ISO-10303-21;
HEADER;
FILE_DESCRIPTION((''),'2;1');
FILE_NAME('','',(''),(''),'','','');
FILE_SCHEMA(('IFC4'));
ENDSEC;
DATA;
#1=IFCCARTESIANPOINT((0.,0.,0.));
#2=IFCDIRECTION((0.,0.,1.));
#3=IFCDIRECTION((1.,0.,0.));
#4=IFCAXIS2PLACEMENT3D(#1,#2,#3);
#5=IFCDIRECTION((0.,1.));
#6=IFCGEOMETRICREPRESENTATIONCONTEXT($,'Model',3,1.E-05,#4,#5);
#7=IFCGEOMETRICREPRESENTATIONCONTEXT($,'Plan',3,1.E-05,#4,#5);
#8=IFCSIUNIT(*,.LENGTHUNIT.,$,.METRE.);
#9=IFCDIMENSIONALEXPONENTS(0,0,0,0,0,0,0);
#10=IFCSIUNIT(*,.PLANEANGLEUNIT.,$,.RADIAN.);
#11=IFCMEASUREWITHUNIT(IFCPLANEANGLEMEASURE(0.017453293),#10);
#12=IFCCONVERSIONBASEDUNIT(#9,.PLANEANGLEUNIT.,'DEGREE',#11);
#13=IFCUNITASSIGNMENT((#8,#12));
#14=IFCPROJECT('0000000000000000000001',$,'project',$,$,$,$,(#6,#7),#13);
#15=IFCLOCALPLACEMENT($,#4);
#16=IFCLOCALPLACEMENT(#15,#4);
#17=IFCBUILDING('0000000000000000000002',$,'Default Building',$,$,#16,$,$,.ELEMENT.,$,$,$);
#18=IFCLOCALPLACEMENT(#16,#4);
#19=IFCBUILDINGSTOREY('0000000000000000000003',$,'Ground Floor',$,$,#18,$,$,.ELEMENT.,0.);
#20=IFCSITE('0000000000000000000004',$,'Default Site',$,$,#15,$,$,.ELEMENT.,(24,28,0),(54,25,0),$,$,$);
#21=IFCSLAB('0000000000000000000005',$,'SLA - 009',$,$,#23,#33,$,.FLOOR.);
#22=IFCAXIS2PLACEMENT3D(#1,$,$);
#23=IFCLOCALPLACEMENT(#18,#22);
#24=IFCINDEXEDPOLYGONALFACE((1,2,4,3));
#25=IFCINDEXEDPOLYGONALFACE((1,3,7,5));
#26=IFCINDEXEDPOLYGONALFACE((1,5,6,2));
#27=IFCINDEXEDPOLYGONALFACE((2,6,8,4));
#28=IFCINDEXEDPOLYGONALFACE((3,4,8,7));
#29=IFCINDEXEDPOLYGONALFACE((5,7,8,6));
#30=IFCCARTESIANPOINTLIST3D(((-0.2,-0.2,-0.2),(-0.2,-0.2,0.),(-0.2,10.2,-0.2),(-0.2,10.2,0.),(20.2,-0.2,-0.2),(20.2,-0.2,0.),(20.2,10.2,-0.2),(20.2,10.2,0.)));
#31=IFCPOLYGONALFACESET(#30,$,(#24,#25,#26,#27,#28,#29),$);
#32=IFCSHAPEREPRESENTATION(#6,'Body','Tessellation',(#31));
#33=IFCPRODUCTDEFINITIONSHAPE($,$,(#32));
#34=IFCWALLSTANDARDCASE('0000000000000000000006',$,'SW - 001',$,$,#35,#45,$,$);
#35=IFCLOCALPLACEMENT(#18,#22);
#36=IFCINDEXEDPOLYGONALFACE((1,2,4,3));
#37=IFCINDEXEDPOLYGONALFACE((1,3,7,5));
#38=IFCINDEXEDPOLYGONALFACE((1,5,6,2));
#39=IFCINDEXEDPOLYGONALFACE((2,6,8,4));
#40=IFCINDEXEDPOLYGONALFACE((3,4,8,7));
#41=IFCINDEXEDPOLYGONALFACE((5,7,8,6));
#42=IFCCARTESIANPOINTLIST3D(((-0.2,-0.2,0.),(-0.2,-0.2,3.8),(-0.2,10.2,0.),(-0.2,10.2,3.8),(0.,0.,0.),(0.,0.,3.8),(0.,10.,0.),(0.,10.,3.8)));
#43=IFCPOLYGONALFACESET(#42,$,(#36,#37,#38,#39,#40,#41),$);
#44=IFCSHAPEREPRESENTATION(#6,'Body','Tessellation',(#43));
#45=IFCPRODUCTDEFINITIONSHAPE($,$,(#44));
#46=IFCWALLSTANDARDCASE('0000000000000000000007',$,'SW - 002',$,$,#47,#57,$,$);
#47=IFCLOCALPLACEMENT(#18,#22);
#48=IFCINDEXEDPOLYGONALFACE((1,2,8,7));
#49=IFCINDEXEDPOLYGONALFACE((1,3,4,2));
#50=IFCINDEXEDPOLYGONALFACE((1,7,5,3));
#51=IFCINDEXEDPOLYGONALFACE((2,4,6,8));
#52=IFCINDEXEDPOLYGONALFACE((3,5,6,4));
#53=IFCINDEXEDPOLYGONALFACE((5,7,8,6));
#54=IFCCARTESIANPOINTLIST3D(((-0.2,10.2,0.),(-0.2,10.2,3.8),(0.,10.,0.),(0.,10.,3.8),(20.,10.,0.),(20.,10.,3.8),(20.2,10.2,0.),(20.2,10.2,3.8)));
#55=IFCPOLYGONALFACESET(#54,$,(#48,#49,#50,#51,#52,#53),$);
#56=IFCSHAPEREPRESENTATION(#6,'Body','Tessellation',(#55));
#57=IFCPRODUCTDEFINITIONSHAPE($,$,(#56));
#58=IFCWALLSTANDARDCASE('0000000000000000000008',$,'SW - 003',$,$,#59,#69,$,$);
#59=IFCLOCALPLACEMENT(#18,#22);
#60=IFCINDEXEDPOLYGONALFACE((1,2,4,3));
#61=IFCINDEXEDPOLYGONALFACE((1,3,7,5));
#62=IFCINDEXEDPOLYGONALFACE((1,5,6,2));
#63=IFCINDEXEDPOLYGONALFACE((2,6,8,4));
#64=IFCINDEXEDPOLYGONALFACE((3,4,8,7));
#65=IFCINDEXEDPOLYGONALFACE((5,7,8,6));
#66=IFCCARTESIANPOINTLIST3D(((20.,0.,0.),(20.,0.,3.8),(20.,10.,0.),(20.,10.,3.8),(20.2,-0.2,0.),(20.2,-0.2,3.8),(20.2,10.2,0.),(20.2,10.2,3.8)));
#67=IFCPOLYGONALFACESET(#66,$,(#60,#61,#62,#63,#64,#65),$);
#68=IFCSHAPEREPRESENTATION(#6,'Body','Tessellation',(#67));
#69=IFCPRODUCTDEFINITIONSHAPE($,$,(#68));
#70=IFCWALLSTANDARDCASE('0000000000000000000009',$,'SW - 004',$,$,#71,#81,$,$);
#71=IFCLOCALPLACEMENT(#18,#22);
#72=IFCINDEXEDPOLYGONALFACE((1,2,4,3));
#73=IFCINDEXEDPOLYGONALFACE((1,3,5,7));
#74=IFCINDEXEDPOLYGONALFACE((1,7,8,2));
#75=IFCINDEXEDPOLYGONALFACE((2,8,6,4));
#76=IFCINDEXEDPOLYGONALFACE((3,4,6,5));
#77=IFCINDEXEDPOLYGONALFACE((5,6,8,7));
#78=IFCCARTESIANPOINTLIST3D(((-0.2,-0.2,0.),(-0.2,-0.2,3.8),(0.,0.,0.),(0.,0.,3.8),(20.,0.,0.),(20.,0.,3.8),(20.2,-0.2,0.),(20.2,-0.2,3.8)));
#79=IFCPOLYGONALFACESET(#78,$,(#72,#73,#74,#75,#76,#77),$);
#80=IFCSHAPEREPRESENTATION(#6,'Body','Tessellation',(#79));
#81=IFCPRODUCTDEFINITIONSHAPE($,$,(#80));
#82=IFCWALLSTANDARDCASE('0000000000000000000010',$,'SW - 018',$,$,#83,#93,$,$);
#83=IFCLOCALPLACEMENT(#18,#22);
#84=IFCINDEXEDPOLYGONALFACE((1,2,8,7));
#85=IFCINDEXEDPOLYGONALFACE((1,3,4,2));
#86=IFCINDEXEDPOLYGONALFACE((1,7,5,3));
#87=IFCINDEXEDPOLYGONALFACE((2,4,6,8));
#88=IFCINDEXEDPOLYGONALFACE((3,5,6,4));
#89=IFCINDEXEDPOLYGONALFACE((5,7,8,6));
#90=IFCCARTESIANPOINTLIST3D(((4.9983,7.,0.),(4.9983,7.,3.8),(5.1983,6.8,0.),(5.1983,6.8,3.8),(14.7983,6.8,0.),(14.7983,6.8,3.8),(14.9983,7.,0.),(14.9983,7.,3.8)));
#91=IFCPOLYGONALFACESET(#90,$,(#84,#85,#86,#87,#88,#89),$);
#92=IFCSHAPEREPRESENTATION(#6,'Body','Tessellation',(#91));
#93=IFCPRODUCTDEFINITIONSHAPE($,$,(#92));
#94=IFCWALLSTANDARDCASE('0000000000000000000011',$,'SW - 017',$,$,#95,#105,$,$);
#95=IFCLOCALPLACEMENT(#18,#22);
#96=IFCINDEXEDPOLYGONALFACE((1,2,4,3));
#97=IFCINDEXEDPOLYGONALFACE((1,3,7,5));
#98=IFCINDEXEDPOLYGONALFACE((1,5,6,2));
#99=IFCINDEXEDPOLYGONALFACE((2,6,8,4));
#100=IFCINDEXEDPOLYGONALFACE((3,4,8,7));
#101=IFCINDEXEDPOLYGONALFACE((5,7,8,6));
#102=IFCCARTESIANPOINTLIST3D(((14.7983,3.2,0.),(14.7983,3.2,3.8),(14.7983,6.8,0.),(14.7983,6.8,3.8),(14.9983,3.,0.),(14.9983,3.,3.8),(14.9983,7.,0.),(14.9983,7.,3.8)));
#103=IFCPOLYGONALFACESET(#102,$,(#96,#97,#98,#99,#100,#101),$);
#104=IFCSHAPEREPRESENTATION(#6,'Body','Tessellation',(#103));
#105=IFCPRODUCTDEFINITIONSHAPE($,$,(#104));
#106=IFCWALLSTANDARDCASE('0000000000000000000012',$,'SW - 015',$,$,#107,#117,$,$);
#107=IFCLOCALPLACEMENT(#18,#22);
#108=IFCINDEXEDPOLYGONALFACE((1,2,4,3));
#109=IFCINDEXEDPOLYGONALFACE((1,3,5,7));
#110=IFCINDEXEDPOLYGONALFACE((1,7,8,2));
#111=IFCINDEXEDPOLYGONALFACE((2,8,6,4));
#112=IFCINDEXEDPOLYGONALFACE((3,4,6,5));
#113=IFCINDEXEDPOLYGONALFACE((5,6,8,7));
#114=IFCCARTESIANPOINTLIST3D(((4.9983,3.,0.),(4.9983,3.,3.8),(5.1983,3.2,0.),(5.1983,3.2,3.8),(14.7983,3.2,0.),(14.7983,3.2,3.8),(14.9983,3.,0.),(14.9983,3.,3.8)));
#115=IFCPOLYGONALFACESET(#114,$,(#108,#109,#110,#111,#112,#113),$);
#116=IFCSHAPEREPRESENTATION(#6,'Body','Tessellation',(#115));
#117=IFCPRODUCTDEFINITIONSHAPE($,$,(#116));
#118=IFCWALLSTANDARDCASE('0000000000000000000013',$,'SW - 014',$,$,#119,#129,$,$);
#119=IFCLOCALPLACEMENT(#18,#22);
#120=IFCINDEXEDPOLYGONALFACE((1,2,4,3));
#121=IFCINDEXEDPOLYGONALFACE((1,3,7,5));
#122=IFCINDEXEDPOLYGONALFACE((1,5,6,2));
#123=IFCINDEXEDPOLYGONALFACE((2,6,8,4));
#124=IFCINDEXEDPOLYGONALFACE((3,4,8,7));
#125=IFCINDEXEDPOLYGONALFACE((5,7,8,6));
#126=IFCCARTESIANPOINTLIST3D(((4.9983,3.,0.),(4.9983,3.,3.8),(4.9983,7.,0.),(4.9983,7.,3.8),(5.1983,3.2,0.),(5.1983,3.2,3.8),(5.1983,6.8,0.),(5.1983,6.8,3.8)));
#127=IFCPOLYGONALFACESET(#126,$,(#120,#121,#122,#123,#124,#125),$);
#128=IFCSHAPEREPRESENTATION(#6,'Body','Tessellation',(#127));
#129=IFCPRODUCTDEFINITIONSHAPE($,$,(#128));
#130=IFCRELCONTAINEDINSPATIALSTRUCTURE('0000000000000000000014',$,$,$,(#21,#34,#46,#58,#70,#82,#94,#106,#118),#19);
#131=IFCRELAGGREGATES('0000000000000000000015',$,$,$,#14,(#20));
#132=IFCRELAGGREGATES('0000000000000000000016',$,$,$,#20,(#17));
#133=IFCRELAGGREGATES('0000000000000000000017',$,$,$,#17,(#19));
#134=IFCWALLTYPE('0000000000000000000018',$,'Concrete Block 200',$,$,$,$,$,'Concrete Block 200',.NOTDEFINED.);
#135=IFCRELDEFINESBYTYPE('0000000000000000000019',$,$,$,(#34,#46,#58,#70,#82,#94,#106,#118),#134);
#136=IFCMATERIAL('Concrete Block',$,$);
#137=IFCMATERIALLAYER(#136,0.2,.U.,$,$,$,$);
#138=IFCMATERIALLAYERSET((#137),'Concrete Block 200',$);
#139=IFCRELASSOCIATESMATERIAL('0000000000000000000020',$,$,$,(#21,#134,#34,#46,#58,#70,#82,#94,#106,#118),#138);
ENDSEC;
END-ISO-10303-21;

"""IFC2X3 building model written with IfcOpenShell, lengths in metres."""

from ifc_helpers import new_model, entity, si_unit, converted_unit, direction, frame, origin_with_axes, place, context, project, spatial, polyline, outline, extrude, material, layer, layer_set, layer_usage, type_object, element, save


model = new_model("IFC2X3")

# Units and contexts
model_context = context("Model", 3, precision=1e-05, world=origin_with_axes(), true_north=direction((0.0, 1.0)))
plan_context = context("Plan", 3, precision=1e-05, world=origin_with_axes(), true_north=direction((0.0, 1.0)))
ifc_project = project(units=[si_unit("LENGTHUNIT", "METRE"), converted_unit("PLANEANGLEUNIT", "DEGREE", entity("IfcPlaneAngleMeasure", 0.017453293), si_unit("PLANEANGLEUNIT", "RADIAN"), dimensions=[0, 0, 0, 0, 0, 0, 0])], contexts=[model_context, plan_context])

# Site, building, storey
site_placement = place(None, origin_with_axes())
site = spatial("IfcSite", under=ifc_project, at=site_placement, Name="Default Site", CompositionType="ELEMENT", RefLatitude=(24, 28, 0), RefLongitude=(54, 25, 0))
building_placement = place(site_placement, origin_with_axes())
building = spatial("IfcBuilding", under=site, at=building_placement, Name="Default Building", CompositionType="ELEMENT")
storey_placement = place(building_placement, origin_with_axes())
storey = spatial("IfcBuildingStorey", under=building, at=storey_placement, Name="Ground Floor", CompositionType="ELEMENT", Elevation=0.0)

# Slab
ifc_material = material(Name="Concrete Block")
ifc_layer = layer(ifc_material, 0.2, ventilated="UNKNOWN")
ifc_layer_set = layer_set([ifc_layer], Name="Concrete Block 200")
ifc_layer_usage_1 = layer_usage(ifc_layer_set, "AXIS3", "NEGATIVE", 0.2)
slab_placement = place(storey_placement, frame((-0.2, 10.2, -0.2), z_axis=(0.0, 0.0, 1.0), x_axis=(1.0, 0.0, 0.0)))
element("IfcSlab", 1, at=slab_placement, inside=storey, material=ifc_layer_usage_1, Name="SLA - 009", PredefinedType="FLOOR", context=model_context, shape_type="SweptSolid", body=[
    extrude(outline(polyline([(0.0, 0.0), (20.4, 0.0), (20.4, -10.4), (0.0, -10.4), (0.0, 0.0)])), origin_with_axes(), (0.0, 0.0, 1.0), 0.2),
])

# Walls
ifc_layer_usage_2 = layer_usage(ifc_layer_set, "AXIS2", "POSITIVE", 0.0)
wall_type = type_object("IfcWallType", Name="Concrete Block 200", ElementType="Concrete Block 200", PredefinedType="NOTDEFINED", material=ifc_layer_set)
wall_1_placement = place(storey_placement, frame((0.0, 0.0, 0.0), z_axis=(0.0, 0.0, 1.0), x_axis=(0.0, 1.0, 0.0)))
element("IfcWallStandardCase", 2, at=wall_1_placement, inside=storey, type_object=wall_type, material=ifc_layer_usage_2, Name="SW - 001", context=model_context, shape_type="SweptSolid", body=[
    extrude(outline(polyline([(0.0, 0.0), (10.0, 0.0), (10.2, 0.2), (-0.2, 0.2), (0.0, 0.0)])), origin_with_axes(), (0.0, 0.0, 1.0), 3.8),
])
ifc_layer_usage_3 = layer_usage(ifc_layer_set, "AXIS2", "POSITIVE", 0.0)
wall_2_placement = place(storey_placement, frame((0.0, 10.0, 0.0), z_axis=(0.0, 0.0, 1.0), x_axis=(1.0, 0.0, 0.0)))
element("IfcWallStandardCase", 3, at=wall_2_placement, inside=storey, type_object=wall_type, material=ifc_layer_usage_3, Name="SW - 002", context=model_context, shape_type="SweptSolid", body=[
    extrude(outline(polyline([(0.0, 0.0), (20.0, 0.0), (20.2, 0.2), (-0.2, 0.2), (0.0, 0.0)])), origin_with_axes(), (0.0, 0.0, 1.0), 3.8),
])
ifc_layer_usage_4 = layer_usage(ifc_layer_set, "AXIS2", "POSITIVE", 0.0)
wall_3_placement = place(storey_placement, frame((20.0, 10.0, 0.0), z_axis=(0.0, 0.0, 1.0), x_axis=(0.0, -1.0, 0.0)))
element("IfcWallStandardCase", 4, at=wall_3_placement, inside=storey, type_object=wall_type, material=ifc_layer_usage_4, Name="SW - 003", context=model_context, shape_type="SweptSolid", body=[
    extrude(outline(polyline([(0.0, 0.0), (10.0, 0.0), (10.2, 0.2), (-0.2, 0.2), (0.0, 0.0)])), origin_with_axes(), (0.0, 0.0, 1.0), 3.8),
])
ifc_layer_usage_5 = layer_usage(ifc_layer_set, "AXIS2", "POSITIVE", 0.0)
wall_4_placement = place(storey_placement, frame((20.0, 0.0, 0.0), z_axis=(0.0, 0.0, 1.0), x_axis=(-1.0, 0.0, 0.0)))
element("IfcWallStandardCase", 5, at=wall_4_placement, inside=storey, type_object=wall_type, material=ifc_layer_usage_5, Name="SW - 004", context=model_context, shape_type="SweptSolid", body=[
    extrude(outline(polyline([(0.0, 0.0), (20.0, 0.0), (20.2, 0.2), (-0.2, 0.2), (0.0, 0.0)])), origin_with_axes(), (0.0, 0.0, 1.0), 3.8),
])
ifc_layer_usage_6 = layer_usage(ifc_layer_set, "AXIS2", "POSITIVE", 0.0)
wall_5_placement = place(storey_placement, frame((14.9983, 7.0, 0.0), z_axis=(0.0, 0.0, 1.0), x_axis=(-1.0, 0.0, 0.0)))
element("IfcWallStandardCase", 6, at=wall_5_placement, inside=storey, type_object=wall_type, material=ifc_layer_usage_6, Name="SW - 018", context=model_context, shape_type="SweptSolid", body=[
    extrude(outline(polyline([(0.0, 0.0), (10.0, 0.0), (9.8, 0.2), (0.2, 0.2), (0.0, 0.0)])), origin_with_axes(), (0.0, 0.0, 1.0), 3.8),
])
ifc_layer_usage_7 = layer_usage(ifc_layer_set, "AXIS2", "POSITIVE", 0.0)
wall_6_placement = place(storey_placement, frame((14.9983, 3.0, 0.0), z_axis=(0.0, 0.0, 1.0), x_axis=(0.0, 1.0, 0.0)))
element("IfcWallStandardCase", 7, at=wall_6_placement, inside=storey, type_object=wall_type, material=ifc_layer_usage_7, Name="SW - 017", context=model_context, shape_type="SweptSolid", body=[
    extrude(outline(polyline([(0.0, 0.0), (4.0, 0.0), (3.8, 0.2), (0.2, 0.2), (0.0, 0.0)])), origin_with_axes(), (0.0, 0.0, 1.0), 3.8),
])
ifc_layer_usage_8 = layer_usage(ifc_layer_set, "AXIS2", "POSITIVE", 0.0)
wall_7_placement = place(storey_placement, frame((4.9983, 3.0, 0.0), z_axis=(0.0, 0.0, 1.0), x_axis=(1.0, 0.0, 0.0)))
element("IfcWallStandardCase", 8, at=wall_7_placement, inside=storey, type_object=wall_type, material=ifc_layer_usage_8, Name="SW - 015", context=model_context, shape_type="SweptSolid", body=[
    extrude(outline(polyline([(0.0, 0.0), (10.0, 0.0), (9.8, 0.2), (0.2, 0.2), (0.0, 0.0)])), origin_with_axes(), (0.0, 0.0, 1.0), 3.8),
])
ifc_layer_usage_9 = layer_usage(ifc_layer_set, "AXIS2", "POSITIVE", 0.0)
wall_8_placement = place(storey_placement, frame((4.9983, 7.0, 0.0), z_axis=(0.0, 0.0, 1.0), x_axis=(0.0, -1.0, 0.0)))
element("IfcWallStandardCase", 9, at=wall_8_placement, inside=storey, type_object=wall_type, material=ifc_layer_usage_9, Name="SW - 014", context=model_context, shape_type="SweptSolid", body=[
    extrude(outline(polyline([(0.0, 0.0), (4.0, 0.0), (3.8, 0.2), (0.2, 0.2), (0.0, 0.0)])), origin_with_axes(), (0.0, 0.0, 1.0), 3.8),
])

save(model, "model.ifc")
